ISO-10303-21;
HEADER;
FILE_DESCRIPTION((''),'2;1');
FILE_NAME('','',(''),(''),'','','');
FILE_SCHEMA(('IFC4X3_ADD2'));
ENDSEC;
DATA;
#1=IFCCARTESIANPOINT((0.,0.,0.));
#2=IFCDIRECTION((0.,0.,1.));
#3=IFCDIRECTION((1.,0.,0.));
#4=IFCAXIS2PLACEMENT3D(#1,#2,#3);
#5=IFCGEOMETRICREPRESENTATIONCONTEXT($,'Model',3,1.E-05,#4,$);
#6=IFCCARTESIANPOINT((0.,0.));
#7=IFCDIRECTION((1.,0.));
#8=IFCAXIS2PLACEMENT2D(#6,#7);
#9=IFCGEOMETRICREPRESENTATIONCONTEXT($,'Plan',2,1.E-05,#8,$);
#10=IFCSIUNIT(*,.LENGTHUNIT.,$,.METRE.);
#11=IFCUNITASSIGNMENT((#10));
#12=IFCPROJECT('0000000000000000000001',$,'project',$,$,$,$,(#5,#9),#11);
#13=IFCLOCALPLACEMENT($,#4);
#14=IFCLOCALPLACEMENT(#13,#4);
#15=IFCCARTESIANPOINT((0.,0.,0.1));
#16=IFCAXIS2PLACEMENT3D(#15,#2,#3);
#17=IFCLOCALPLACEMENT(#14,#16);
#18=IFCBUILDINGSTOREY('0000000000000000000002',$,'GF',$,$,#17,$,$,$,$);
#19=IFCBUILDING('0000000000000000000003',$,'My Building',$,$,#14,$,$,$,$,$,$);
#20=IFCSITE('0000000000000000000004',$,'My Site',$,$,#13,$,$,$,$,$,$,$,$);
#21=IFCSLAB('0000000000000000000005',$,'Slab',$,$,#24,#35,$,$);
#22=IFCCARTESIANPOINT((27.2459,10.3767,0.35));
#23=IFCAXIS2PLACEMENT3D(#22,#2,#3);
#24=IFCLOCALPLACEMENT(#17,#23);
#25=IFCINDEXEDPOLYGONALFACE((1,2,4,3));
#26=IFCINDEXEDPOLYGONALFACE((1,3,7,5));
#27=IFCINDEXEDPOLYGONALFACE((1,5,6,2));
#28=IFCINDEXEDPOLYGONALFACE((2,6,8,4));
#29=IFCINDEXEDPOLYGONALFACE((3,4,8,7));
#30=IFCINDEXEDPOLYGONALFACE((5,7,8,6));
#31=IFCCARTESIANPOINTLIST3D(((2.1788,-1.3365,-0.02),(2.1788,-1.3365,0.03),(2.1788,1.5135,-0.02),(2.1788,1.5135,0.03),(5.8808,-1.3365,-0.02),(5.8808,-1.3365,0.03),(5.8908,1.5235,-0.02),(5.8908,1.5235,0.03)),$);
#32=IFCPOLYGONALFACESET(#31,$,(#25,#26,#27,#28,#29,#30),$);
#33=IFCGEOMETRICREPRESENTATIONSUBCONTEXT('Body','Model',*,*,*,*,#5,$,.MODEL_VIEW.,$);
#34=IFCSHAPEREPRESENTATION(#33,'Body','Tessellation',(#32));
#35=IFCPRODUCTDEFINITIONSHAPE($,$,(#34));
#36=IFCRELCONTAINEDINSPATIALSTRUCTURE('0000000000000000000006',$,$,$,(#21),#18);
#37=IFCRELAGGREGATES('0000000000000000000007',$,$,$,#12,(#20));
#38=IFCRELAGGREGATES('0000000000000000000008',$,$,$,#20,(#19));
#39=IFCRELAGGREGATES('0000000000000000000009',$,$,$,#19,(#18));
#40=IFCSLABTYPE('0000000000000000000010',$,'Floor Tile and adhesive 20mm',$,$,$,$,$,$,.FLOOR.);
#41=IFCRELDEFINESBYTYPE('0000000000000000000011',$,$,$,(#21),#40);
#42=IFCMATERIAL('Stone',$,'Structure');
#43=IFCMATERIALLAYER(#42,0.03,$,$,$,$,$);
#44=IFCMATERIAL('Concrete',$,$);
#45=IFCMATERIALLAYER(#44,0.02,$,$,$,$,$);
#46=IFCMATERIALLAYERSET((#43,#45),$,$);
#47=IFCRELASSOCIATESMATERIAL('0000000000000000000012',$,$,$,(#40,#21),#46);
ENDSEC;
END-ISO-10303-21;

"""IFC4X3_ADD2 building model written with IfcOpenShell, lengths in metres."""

from ifc_helpers import new_model, si_unit, frame, origin_with_axes, origin_2d_with_axis, place, context, subcontext, project, spatial, indexed_curve, outline, extrude, material, layer, layer_set, layer_usage, type_object, element, save


model = new_model("IFC4X3_ADD2")

# Units and contexts
model_context = context("Model", 3, precision=1e-05, world=origin_with_axes())
plan_context = context("Plan", 2, precision=1e-05, world=origin_2d_with_axis())
body_context_1 = subcontext(model_context, "Body", "Model", "MODEL_VIEW")
ifc_project = project(units=[si_unit("LENGTHUNIT", "METRE")], contexts=[model_context, plan_context])

# Site, building, storey
site_placement = place(None, origin_with_axes())
site = spatial("IfcSite", under=ifc_project, at=site_placement, Name="My Site")
building_placement = place(site_placement, origin_with_axes())
building = spatial("IfcBuilding", under=site, at=building_placement, Name="My Building")
storey_placement = place(building_placement, frame((0.0, 0.0, 0.1), z_axis=(0.0, 0.0, 1.0), x_axis=(1.0, 0.0, 0.0)))
storey = spatial("IfcBuildingStorey", under=building, at=storey_placement, Name="GF")

# Slab
ifc_material_1 = material(Name="Stone", Category="Structure")
ifc_layer_1 = layer(ifc_material_1, 0.03)
ifc_material_2 = material(Name="Concrete")
ifc_layer_2 = layer(ifc_material_2, 0.02)
ifc_layer_set_1 = layer_set([ifc_layer_1, ifc_layer_2])
ifc_layer_usage_1 = layer_usage(ifc_layer_set_1, "AXIS3", "POSITIVE", -0.02)
slab_type = type_object("IfcSlabType", Name="Floor Tile and adhesive 20mm", PredefinedType="FLOOR", material=ifc_layer_set_1)
slab_placement = place(storey_placement, frame((27.2459, 10.3767, 0.35), z_axis=(0.0, 0.0, 1.0), x_axis=(1.0, 0.0, 0.0)))
element("IfcSlab", 1, at=slab_placement, inside=storey, type_object=slab_type, material=ifc_layer_usage_1, Name="Slab", context=body_context_1, shape_type="SweptSolid", body=[
    extrude(outline(indexed_curve([(2.1788, -1.3365), (5.8808, -1.3365), (5.8908, 1.5235), (2.1788, 1.5135), (2.1788, -1.3365)])), frame((0.0, 0.0, -0.02), z_axis=(0.0, 0.0, 1.0), x_axis=(1.0, 0.0, 0.0)), (0.0, 0.0, 1.0), 0.05),
])

save(model, "model.ifc")
